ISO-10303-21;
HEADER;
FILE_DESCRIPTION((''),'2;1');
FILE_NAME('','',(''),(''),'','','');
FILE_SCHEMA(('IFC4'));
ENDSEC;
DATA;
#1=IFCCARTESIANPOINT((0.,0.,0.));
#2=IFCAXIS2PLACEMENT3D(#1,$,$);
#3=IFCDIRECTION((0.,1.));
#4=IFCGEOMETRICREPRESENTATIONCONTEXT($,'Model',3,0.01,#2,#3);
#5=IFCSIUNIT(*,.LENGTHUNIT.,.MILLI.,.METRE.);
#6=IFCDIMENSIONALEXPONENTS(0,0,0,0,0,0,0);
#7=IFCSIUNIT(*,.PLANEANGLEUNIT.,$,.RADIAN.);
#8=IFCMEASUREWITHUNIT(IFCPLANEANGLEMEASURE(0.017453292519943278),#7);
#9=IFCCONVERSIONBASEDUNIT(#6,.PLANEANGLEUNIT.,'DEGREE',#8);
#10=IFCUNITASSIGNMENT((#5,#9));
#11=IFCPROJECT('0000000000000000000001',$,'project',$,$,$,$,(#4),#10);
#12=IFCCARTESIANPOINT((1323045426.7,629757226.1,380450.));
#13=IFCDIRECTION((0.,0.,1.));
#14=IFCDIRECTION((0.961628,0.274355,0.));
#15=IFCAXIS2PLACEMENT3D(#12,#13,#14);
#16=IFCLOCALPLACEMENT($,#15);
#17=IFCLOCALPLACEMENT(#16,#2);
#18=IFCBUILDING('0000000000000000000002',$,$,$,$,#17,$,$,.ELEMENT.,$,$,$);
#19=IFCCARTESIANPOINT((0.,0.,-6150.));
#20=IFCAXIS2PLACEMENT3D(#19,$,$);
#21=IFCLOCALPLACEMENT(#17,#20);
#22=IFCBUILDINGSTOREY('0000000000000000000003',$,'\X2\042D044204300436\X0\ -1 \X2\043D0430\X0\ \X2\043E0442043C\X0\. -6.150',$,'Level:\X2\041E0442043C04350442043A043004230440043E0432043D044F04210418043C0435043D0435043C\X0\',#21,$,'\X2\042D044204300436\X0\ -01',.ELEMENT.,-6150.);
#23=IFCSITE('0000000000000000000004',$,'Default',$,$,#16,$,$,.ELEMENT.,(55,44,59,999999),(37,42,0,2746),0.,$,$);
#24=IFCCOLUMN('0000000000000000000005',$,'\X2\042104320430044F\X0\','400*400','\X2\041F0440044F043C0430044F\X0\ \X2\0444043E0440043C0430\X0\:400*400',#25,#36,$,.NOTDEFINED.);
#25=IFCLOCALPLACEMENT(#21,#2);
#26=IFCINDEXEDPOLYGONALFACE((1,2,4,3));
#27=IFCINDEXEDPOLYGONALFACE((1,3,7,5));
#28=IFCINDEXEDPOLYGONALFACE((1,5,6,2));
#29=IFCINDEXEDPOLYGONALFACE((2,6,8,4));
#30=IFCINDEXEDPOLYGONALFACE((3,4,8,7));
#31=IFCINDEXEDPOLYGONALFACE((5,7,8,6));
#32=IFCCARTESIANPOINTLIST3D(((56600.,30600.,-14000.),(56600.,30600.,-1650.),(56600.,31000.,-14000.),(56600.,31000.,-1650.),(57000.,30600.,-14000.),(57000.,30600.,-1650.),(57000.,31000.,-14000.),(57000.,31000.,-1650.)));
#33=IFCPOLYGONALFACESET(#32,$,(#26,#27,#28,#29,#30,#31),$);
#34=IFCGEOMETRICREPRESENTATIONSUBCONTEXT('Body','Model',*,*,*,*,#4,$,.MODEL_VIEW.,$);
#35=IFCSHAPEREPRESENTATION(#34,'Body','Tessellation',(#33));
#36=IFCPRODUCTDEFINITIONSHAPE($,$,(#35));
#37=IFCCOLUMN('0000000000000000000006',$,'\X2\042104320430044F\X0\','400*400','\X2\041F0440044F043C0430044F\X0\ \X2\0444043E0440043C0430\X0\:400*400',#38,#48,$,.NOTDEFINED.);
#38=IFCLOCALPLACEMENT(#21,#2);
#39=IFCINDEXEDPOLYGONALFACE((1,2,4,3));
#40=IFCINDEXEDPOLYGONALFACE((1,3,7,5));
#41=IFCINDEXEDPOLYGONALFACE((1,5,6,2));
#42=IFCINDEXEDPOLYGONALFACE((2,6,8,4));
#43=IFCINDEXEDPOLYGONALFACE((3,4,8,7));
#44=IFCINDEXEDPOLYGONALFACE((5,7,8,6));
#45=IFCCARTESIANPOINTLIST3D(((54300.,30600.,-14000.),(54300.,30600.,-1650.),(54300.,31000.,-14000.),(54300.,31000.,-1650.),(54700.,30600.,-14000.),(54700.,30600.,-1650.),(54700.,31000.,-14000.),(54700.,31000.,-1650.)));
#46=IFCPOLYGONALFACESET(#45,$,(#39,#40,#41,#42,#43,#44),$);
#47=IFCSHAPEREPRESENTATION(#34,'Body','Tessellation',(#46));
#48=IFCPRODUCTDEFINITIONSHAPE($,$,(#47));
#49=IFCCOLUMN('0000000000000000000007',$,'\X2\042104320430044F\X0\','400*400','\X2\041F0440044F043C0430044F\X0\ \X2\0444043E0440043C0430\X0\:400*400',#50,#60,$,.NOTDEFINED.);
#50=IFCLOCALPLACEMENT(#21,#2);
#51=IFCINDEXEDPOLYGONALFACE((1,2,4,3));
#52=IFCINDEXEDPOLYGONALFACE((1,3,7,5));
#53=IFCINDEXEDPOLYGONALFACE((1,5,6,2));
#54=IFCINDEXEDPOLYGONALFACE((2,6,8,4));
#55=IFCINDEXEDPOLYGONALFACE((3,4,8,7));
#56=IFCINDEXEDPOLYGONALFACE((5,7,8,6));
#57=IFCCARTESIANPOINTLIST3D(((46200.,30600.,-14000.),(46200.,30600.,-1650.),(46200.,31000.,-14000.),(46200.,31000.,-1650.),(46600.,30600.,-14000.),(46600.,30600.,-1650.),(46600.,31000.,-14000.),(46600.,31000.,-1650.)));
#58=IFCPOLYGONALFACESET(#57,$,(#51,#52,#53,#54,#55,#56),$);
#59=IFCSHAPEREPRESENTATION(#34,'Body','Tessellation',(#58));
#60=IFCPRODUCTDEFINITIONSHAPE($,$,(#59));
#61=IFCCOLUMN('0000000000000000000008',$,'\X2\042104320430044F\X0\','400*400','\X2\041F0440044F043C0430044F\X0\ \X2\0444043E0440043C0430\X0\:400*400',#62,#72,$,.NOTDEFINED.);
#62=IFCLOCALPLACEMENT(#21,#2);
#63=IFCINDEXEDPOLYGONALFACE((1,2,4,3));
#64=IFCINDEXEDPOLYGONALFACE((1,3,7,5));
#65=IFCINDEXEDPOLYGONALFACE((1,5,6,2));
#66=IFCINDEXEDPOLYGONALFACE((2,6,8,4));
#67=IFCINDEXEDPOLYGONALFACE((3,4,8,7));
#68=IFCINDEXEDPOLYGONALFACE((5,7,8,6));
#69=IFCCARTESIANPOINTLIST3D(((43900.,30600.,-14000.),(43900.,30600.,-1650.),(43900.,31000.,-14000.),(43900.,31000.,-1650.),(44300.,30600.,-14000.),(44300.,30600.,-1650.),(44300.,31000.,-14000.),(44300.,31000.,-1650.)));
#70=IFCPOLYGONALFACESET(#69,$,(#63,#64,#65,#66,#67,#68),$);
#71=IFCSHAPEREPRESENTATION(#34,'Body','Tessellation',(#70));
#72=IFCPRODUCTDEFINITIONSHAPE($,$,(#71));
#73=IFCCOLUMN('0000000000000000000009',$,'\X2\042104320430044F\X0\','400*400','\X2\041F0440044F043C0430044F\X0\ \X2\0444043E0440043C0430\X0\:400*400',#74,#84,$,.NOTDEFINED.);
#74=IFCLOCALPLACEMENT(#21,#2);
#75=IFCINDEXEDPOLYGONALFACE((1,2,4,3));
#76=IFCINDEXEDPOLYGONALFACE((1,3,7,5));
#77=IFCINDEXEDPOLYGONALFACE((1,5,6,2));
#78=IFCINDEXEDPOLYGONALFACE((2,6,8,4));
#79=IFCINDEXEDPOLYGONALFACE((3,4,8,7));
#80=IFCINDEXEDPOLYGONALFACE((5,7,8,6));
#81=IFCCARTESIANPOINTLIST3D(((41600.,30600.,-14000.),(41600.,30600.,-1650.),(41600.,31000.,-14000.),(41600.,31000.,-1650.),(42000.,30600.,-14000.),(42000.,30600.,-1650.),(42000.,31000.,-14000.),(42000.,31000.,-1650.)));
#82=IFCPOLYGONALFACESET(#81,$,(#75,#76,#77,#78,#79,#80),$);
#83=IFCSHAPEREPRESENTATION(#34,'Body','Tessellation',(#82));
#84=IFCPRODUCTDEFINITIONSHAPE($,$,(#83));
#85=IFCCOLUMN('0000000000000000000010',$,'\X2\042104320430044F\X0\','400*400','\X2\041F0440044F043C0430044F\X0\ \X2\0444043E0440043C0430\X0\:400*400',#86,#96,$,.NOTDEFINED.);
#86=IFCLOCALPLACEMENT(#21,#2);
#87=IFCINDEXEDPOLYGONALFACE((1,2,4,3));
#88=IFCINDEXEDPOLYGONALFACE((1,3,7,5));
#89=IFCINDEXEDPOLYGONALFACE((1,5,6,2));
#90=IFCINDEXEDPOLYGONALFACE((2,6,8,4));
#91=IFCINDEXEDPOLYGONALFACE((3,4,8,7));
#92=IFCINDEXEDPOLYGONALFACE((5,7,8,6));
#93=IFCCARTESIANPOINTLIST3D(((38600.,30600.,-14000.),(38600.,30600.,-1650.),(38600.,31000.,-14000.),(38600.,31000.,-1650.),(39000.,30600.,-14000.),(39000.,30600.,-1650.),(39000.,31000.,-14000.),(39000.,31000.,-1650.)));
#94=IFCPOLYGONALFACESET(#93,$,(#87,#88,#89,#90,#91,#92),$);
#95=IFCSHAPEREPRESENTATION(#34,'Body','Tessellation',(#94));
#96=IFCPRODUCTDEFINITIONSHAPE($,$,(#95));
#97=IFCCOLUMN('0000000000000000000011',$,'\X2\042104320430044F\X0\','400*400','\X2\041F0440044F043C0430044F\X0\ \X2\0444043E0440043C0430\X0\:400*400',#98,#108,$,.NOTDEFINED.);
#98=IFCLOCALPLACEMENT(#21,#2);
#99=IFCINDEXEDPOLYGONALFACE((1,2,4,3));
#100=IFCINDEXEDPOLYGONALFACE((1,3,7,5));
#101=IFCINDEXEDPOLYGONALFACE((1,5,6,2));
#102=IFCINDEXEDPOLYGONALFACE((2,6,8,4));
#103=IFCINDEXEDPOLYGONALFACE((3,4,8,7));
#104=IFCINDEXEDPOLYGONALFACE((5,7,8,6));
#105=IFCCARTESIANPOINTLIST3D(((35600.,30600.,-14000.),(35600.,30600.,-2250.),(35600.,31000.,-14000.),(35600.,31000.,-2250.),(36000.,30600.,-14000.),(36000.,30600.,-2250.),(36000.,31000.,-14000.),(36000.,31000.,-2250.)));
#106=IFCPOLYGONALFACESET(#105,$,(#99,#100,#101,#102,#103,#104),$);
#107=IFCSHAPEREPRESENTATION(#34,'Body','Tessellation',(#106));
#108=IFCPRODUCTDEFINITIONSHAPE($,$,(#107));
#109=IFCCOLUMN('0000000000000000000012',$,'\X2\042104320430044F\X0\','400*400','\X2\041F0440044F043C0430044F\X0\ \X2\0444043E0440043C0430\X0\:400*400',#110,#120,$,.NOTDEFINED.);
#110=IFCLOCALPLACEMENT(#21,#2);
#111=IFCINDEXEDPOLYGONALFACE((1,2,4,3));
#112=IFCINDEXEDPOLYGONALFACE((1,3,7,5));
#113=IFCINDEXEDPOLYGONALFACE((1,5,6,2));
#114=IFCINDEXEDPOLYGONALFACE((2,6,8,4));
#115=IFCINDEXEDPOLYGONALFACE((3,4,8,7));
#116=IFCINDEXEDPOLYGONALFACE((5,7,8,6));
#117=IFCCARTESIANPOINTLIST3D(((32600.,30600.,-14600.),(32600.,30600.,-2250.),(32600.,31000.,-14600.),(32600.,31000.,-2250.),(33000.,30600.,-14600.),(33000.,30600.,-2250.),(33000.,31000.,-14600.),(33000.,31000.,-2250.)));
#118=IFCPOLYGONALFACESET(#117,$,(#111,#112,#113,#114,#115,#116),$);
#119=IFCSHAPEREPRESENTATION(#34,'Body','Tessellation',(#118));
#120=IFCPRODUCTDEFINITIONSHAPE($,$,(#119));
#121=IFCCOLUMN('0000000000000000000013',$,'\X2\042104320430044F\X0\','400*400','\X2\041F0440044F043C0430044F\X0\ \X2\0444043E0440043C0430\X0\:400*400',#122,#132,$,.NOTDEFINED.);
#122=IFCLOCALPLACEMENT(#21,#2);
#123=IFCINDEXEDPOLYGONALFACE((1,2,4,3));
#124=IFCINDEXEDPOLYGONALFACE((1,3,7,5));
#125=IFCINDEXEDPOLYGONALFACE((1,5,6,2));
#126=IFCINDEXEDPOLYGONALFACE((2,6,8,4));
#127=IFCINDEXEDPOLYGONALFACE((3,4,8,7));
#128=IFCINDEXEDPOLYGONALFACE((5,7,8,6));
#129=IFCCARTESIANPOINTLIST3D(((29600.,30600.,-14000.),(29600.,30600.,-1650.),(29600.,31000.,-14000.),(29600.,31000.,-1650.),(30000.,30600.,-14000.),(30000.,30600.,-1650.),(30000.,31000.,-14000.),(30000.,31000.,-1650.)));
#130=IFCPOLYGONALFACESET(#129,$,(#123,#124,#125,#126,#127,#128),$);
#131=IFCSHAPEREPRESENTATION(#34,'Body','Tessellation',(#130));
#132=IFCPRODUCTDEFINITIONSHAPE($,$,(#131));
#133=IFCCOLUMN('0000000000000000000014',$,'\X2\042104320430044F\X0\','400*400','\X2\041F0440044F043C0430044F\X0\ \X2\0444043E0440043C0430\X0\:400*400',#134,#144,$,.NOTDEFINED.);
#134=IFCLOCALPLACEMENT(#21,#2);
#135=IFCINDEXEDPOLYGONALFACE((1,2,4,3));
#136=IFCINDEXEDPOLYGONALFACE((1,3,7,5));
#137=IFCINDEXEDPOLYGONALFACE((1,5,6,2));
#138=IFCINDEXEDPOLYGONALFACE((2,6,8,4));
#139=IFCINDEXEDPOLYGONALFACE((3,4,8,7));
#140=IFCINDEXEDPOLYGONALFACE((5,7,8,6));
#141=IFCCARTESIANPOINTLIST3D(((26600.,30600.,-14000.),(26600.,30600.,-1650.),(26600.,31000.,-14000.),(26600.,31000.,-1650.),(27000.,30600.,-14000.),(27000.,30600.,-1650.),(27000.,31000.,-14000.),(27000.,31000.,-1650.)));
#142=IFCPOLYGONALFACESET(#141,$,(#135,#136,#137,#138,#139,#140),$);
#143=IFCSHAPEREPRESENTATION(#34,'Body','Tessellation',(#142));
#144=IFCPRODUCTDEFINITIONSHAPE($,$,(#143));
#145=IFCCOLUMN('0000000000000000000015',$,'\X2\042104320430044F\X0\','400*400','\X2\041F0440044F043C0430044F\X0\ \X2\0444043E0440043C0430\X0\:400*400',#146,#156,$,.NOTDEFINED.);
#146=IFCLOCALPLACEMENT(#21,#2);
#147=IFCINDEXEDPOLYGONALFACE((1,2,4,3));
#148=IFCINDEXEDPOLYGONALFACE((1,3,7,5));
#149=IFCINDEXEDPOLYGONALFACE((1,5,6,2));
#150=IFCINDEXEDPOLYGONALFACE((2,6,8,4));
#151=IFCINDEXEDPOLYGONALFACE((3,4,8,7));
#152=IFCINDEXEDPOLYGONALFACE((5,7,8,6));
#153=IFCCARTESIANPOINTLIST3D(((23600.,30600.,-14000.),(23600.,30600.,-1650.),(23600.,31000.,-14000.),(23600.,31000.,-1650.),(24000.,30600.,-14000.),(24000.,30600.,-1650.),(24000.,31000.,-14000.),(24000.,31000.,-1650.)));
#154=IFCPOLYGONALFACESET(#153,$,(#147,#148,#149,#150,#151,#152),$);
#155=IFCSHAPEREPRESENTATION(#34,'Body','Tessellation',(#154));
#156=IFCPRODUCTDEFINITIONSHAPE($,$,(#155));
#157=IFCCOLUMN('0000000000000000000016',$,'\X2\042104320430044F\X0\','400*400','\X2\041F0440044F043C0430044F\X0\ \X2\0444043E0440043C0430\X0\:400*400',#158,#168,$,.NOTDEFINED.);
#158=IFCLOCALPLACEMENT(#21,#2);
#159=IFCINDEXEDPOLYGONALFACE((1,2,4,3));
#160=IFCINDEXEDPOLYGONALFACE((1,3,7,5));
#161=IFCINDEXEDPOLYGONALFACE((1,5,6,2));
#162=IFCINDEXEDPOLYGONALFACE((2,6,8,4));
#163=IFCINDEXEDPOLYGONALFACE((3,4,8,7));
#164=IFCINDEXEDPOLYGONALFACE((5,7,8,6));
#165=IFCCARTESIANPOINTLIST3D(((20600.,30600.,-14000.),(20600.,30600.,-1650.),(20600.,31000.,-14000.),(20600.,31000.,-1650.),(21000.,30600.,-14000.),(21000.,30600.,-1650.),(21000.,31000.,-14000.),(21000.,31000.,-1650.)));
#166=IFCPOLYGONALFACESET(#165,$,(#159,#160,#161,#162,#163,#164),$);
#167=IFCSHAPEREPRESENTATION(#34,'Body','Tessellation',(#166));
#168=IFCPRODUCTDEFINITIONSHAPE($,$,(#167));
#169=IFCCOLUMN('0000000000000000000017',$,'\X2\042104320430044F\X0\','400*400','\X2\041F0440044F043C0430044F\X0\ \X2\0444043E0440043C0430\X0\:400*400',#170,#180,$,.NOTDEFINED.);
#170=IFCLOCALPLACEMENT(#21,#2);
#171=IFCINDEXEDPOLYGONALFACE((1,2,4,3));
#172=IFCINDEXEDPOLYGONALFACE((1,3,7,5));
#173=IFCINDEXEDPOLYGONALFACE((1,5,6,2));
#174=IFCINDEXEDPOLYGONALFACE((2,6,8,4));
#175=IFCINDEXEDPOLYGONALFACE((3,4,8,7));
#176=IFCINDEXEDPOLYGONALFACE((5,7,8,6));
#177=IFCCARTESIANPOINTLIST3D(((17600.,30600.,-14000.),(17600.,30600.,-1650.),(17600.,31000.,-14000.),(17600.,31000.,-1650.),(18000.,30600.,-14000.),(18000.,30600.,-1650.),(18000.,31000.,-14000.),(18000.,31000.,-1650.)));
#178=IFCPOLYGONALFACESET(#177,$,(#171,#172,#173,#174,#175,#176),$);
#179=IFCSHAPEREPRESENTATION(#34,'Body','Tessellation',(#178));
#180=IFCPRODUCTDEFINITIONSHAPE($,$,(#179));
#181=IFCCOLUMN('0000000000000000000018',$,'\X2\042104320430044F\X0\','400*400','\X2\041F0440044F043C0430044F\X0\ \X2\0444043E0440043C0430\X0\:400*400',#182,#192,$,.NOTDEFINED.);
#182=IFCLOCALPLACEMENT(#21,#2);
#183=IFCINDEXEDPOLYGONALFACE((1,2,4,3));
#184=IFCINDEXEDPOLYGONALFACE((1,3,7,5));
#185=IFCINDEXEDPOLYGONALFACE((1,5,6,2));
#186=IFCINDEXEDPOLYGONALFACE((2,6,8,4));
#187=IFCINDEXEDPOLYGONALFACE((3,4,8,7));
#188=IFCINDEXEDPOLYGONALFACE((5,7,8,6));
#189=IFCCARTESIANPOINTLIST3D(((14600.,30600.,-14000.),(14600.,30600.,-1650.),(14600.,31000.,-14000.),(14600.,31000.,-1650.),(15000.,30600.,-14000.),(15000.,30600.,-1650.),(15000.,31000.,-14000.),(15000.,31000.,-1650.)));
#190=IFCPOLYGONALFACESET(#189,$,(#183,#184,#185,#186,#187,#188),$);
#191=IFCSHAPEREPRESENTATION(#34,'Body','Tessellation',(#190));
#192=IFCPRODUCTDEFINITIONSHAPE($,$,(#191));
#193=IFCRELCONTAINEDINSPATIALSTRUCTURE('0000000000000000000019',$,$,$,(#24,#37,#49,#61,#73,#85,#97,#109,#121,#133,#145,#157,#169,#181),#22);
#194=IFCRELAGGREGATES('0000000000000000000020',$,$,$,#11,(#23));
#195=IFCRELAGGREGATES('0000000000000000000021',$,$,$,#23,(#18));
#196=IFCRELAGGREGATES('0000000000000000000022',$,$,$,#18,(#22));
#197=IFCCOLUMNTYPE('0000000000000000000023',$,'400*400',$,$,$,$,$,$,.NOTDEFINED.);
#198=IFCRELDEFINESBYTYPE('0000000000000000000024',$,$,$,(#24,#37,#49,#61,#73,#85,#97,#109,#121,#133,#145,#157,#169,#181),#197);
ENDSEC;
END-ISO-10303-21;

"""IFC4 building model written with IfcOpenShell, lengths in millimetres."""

from ifc_helpers import new_model, entity, si_unit, converted_unit, direction, frame, origin, place, context, subcontext, project, spatial, indexed_curve, outline, extrude, type_object, element, save


model = new_model("IFC4")

# Units and contexts
model_context = context("Model", 3, precision=0.01, world=origin(), true_north=direction((0.0, 1.0)))
body_context = subcontext(model_context, "Body", "Model", "MODEL_VIEW")
ifc_project = project(units=[si_unit("LENGTHUNIT", "METRE", prefix="MILLI"), converted_unit("PLANEANGLEUNIT", "DEGREE", entity("IfcPlaneAngleMeasure", 0.017453292519943278), si_unit("PLANEANGLEUNIT", "RADIAN"), dimensions=[0, 0, 0, 0, 0, 0, 0])], contexts=[model_context])

# Site, building, storey
site_placement = place(None, frame((1323045426.7, 629757226.1, 380450.0), z_axis=(0.0, 0.0, 1.0), x_axis=(0.961628, 0.274355, 0.0)))
site = spatial("IfcSite", under=ifc_project, at=site_placement, Name="Default", CompositionType="ELEMENT", RefLatitude=(55, 44, 59, 999999), RefLongitude=(37, 42, 0, 2746), RefElevation=0.0)
building_placement = place(site_placement, origin())
building = spatial("IfcBuilding", under=site, at=building_placement, CompositionType="ELEMENT")
storey_placement = place(building_placement, frame((0.0, 0.0, -6150.0)))
storey = spatial("IfcBuildingStorey", under=building, at=storey_placement, Name="Этаж -1 на отм. -6.150", ObjectType="Level:ОтметкаУровняСИменем", LongName="Этаж -01", CompositionType="ELEMENT", Elevation=-6150.0)

# Columns
column_type = type_object("IfcColumnType", Name="400*400", PredefinedType="NOTDEFINED")
column_1_placement = place(storey_placement, origin())
element("IfcColumn", 1, at=column_1_placement, inside=storey, type_object=column_type, Name="Свая", Description="400*400", ObjectType="Прямая форма:400*400", PredefinedType="NOTDEFINED", context=body_context, shape_type="SweptSolid", body=[
    extrude(outline(indexed_curve([(-200.0, -200.0), (200.0, -200.0), (200.0, 200.0), (-200.0, 200.0), (-200.0, -200.0)], self_intersect=False)), frame((56800.0, 30800.0, -14000.0), z_axis=(0.0, 0.0, 1.0), x_axis=(0.0, 1.0, 0.0)), (0.0, 0.0, 1.0), 12350.0),
])
column_2_placement = place(storey_placement, origin())
element("IfcColumn", 2, at=column_2_placement, inside=storey, type_object=column_type, Name="Свая", Description="400*400", ObjectType="Прямая форма:400*400", PredefinedType="NOTDEFINED", context=body_context, shape_type="SweptSolid", body=[
    extrude(outline(indexed_curve([(-200.0, -200.0), (200.0, -200.0), (200.0, 200.0), (-200.0, 200.0), (-200.0, -200.0)], self_intersect=False)), frame((54500.0, 30800.0, -14000.0), z_axis=(0.0, 0.0, 1.0), x_axis=(0.0, 1.0, 0.0)), (0.0, 0.0, 1.0), 12350.0),
])
column_3_placement = place(storey_placement, origin())
element("IfcColumn", 3, at=column_3_placement, inside=storey, type_object=column_type, Name="Свая", Description="400*400", ObjectType="Прямая форма:400*400", PredefinedType="NOTDEFINED", context=body_context, shape_type="SweptSolid", body=[
    extrude(outline(indexed_curve([(-200.0, -200.0), (200.0, -200.0), (200.0, 200.0), (-200.0, 200.0), (-200.0, -200.0)], self_intersect=False)), frame((46400.0, 30800.0, -14000.0), z_axis=(0.0, 0.0, 1.0), x_axis=(0.0, 1.0, 0.0)), (0.0, 0.0, 1.0), 12350.0),
])
column_4_placement = place(storey_placement, origin())
element("IfcColumn", 4, at=column_4_placement, inside=storey, type_object=column_type, Name="Свая", Description="400*400", ObjectType="Прямая форма:400*400", PredefinedType="NOTDEFINED", context=body_context, shape_type="SweptSolid", body=[
    extrude(outline(indexed_curve([(-200.0, -200.0), (200.0, -200.0), (200.0, 200.0), (-200.0, 200.0), (-200.0, -200.0)], self_intersect=False)), frame((44100.0, 30800.0, -14000.0), z_axis=(0.0, 0.0, 1.0), x_axis=(0.0, 1.0, 0.0)), (0.0, 0.0, 1.0), 12350.0),
])
column_5_placement = place(storey_placement, origin())
element("IfcColumn", 5, at=column_5_placement, inside=storey, type_object=column_type, Name="Свая", Description="400*400", ObjectType="Прямая форма:400*400", PredefinedType="NOTDEFINED", context=body_context, shape_type="SweptSolid", body=[
    extrude(outline(indexed_curve([(-200.0, -200.0), (200.0, -200.0), (200.0, 200.0), (-200.0, 200.0), (-200.0, -200.0)], self_intersect=False)), frame((41800.0, 30800.0, -14000.0), z_axis=(0.0, 0.0, 1.0), x_axis=(0.0, 1.0, 0.0)), (0.0, 0.0, 1.0), 12350.0),
])
column_6_placement = place(storey_placement, origin())
element("IfcColumn", 6, at=column_6_placement, inside=storey, type_object=column_type, Name="Свая", Description="400*400", ObjectType="Прямая форма:400*400", PredefinedType="NOTDEFINED", context=body_context, shape_type="SweptSolid", body=[
    extrude(outline(indexed_curve([(-200.0, -200.0), (200.0, -200.0), (200.0, 200.0), (-200.0, 200.0), (-200.0, -200.0)], self_intersect=False)), frame((38800.0, 30800.0, -14000.0), z_axis=(0.0, 0.0, 1.0), x_axis=(0.0, 1.0, 0.0)), (0.0, 0.0, 1.0), 12350.0),
])
column_7_placement = place(storey_placement, origin())
element("IfcColumn", 7, at=column_7_placement, inside=storey, type_object=column_type, Name="Свая", Description="400*400", ObjectType="Прямая форма:400*400", PredefinedType="NOTDEFINED", context=body_context, shape_type="SweptSolid", body=[
    extrude(outline(indexed_curve([(-200.0, -200.0), (200.0, -200.0), (200.0, 200.0), (-200.0, 200.0), (-200.0, -200.0)], self_intersect=False)), frame((35800.0, 30800.0, -14000.0), z_axis=(0.0, 0.0, 1.0), x_axis=(0.0, 1.0, 0.0)), (0.0, 0.0, 1.0), 11750.0),
])
column_8_placement = place(storey_placement, origin())
element("IfcColumn", 8, at=column_8_placement, inside=storey, type_object=column_type, Name="Свая", Description="400*400", ObjectType="Прямая форма:400*400", PredefinedType="NOTDEFINED", context=body_context, shape_type="SweptSolid", body=[
    extrude(outline(indexed_curve([(-200.0, -200.0), (200.0, -200.0), (200.0, 200.0), (-200.0, 200.0), (-200.0, -200.0)], self_intersect=False)), frame((32800.0, 30800.0, -14600.0), z_axis=(0.0, 0.0, 1.0), x_axis=(0.0, 1.0, 0.0)), (0.0, 0.0, 1.0), 12350.0),
])
column_9_placement = place(storey_placement, origin())
element("IfcColumn", 9, at=column_9_placement, inside=storey, type_object=column_type, Name="Свая", Description="400*400", ObjectType="Прямая форма:400*400", PredefinedType="NOTDEFINED", context=body_context, shape_type="SweptSolid", body=[
    extrude(outline(indexed_curve([(-200.0, -200.0), (200.0, -200.0), (200.0, 200.0), (-200.0, 200.0), (-200.0, -200.0)], self_intersect=False)), frame((29800.0, 30800.0, -14000.0), z_axis=(0.0, 0.0, 1.0), x_axis=(0.0, 1.0, 0.0)), (0.0, 0.0, 1.0), 12350.0),
])
column_10_placement = place(storey_placement, origin())
element("IfcColumn", 10, at=column_10_placement, inside=storey, type_object=column_type, Name="Свая", Description="400*400", ObjectType="Прямая форма:400*400", PredefinedType="NOTDEFINED", context=body_context, shape_type="SweptSolid", body=[
    extrude(outline(indexed_curve([(-200.0, -200.0), (200.0, -200.0), (200.0, 200.0), (-200.0, 200.0), (-200.0, -200.0)], self_intersect=False)), frame((26800.0, 30800.0, -14000.0), z_axis=(0.0, 0.0, 1.0), x_axis=(0.0, 1.0, 0.0)), (0.0, 0.0, 1.0), 12350.0),
])
column_11_placement = place(storey_placement, origin())
element("IfcColumn", 11, at=column_11_placement, inside=storey, type_object=column_type, Name="Свая", Description="400*400", ObjectType="Прямая форма:400*400", PredefinedType="NOTDEFINED", context=body_context, shape_type="SweptSolid", body=[
    extrude(outline(indexed_curve([(-200.0, -200.0), (200.0, -200.0), (200.0, 200.0), (-200.0, 200.0), (-200.0, -200.0)], self_intersect=False)), frame((23800.0, 30800.0, -14000.0), z_axis=(0.0, 0.0, 1.0), x_axis=(0.0, 1.0, 0.0)), (0.0, 0.0, 1.0), 12350.0),
])
column_12_placement = place(storey_placement, origin())
element("IfcColumn", 12, at=column_12_placement, inside=storey, type_object=column_type, Name="Свая", Description="400*400", ObjectType="Прямая форма:400*400", PredefinedType="NOTDEFINED", context=body_context, shape_type="SweptSolid", body=[
    extrude(outline(indexed_curve([(-200.0, -200.0), (200.0, -200.0), (200.0, 200.0), (-200.0, 200.0), (-200.0, -200.0)], self_intersect=False)), frame((20800.0, 30800.0, -14000.0), z_axis=(0.0, 0.0, 1.0), x_axis=(0.0, 1.0, 0.0)), (0.0, 0.0, 1.0), 12350.0),
])
column_13_placement = place(storey_placement, origin())
element("IfcColumn", 13, at=column_13_placement, inside=storey, type_object=column_type, Name="Свая", Description="400*400", ObjectType="Прямая форма:400*400", PredefinedType="NOTDEFINED", context=body_context, shape_type="SweptSolid", body=[
    extrude(outline(indexed_curve([(-200.0, -200.0), (200.0, -200.0), (200.0, 200.0), (-200.0, 200.0), (-200.0, -200.0)], self_intersect=False)), frame((17800.0, 30800.0, -14000.0), z_axis=(0.0, 0.0, 1.0), x_axis=(0.0, 1.0, 0.0)), (0.0, 0.0, 1.0), 12350.0),
])
column_14_placement = place(storey_placement, origin())
element("IfcColumn", 14, at=column_14_placement, inside=storey, type_object=column_type, Name="Свая", Description="400*400", ObjectType="Прямая форма:400*400", PredefinedType="NOTDEFINED", context=body_context, shape_type="SweptSolid", body=[
    extrude(outline(indexed_curve([(-200.0, -200.0), (200.0, -200.0), (200.0, 200.0), (-200.0, 200.0), (-200.0, -200.0)], self_intersect=False)), frame((14800.0, 30800.0, -14000.0), z_axis=(0.0, 0.0, 1.0), x_axis=(0.0, 1.0, 0.0)), (0.0, 0.0, 1.0), 12350.0),
])

save(model, "model.ifc")
